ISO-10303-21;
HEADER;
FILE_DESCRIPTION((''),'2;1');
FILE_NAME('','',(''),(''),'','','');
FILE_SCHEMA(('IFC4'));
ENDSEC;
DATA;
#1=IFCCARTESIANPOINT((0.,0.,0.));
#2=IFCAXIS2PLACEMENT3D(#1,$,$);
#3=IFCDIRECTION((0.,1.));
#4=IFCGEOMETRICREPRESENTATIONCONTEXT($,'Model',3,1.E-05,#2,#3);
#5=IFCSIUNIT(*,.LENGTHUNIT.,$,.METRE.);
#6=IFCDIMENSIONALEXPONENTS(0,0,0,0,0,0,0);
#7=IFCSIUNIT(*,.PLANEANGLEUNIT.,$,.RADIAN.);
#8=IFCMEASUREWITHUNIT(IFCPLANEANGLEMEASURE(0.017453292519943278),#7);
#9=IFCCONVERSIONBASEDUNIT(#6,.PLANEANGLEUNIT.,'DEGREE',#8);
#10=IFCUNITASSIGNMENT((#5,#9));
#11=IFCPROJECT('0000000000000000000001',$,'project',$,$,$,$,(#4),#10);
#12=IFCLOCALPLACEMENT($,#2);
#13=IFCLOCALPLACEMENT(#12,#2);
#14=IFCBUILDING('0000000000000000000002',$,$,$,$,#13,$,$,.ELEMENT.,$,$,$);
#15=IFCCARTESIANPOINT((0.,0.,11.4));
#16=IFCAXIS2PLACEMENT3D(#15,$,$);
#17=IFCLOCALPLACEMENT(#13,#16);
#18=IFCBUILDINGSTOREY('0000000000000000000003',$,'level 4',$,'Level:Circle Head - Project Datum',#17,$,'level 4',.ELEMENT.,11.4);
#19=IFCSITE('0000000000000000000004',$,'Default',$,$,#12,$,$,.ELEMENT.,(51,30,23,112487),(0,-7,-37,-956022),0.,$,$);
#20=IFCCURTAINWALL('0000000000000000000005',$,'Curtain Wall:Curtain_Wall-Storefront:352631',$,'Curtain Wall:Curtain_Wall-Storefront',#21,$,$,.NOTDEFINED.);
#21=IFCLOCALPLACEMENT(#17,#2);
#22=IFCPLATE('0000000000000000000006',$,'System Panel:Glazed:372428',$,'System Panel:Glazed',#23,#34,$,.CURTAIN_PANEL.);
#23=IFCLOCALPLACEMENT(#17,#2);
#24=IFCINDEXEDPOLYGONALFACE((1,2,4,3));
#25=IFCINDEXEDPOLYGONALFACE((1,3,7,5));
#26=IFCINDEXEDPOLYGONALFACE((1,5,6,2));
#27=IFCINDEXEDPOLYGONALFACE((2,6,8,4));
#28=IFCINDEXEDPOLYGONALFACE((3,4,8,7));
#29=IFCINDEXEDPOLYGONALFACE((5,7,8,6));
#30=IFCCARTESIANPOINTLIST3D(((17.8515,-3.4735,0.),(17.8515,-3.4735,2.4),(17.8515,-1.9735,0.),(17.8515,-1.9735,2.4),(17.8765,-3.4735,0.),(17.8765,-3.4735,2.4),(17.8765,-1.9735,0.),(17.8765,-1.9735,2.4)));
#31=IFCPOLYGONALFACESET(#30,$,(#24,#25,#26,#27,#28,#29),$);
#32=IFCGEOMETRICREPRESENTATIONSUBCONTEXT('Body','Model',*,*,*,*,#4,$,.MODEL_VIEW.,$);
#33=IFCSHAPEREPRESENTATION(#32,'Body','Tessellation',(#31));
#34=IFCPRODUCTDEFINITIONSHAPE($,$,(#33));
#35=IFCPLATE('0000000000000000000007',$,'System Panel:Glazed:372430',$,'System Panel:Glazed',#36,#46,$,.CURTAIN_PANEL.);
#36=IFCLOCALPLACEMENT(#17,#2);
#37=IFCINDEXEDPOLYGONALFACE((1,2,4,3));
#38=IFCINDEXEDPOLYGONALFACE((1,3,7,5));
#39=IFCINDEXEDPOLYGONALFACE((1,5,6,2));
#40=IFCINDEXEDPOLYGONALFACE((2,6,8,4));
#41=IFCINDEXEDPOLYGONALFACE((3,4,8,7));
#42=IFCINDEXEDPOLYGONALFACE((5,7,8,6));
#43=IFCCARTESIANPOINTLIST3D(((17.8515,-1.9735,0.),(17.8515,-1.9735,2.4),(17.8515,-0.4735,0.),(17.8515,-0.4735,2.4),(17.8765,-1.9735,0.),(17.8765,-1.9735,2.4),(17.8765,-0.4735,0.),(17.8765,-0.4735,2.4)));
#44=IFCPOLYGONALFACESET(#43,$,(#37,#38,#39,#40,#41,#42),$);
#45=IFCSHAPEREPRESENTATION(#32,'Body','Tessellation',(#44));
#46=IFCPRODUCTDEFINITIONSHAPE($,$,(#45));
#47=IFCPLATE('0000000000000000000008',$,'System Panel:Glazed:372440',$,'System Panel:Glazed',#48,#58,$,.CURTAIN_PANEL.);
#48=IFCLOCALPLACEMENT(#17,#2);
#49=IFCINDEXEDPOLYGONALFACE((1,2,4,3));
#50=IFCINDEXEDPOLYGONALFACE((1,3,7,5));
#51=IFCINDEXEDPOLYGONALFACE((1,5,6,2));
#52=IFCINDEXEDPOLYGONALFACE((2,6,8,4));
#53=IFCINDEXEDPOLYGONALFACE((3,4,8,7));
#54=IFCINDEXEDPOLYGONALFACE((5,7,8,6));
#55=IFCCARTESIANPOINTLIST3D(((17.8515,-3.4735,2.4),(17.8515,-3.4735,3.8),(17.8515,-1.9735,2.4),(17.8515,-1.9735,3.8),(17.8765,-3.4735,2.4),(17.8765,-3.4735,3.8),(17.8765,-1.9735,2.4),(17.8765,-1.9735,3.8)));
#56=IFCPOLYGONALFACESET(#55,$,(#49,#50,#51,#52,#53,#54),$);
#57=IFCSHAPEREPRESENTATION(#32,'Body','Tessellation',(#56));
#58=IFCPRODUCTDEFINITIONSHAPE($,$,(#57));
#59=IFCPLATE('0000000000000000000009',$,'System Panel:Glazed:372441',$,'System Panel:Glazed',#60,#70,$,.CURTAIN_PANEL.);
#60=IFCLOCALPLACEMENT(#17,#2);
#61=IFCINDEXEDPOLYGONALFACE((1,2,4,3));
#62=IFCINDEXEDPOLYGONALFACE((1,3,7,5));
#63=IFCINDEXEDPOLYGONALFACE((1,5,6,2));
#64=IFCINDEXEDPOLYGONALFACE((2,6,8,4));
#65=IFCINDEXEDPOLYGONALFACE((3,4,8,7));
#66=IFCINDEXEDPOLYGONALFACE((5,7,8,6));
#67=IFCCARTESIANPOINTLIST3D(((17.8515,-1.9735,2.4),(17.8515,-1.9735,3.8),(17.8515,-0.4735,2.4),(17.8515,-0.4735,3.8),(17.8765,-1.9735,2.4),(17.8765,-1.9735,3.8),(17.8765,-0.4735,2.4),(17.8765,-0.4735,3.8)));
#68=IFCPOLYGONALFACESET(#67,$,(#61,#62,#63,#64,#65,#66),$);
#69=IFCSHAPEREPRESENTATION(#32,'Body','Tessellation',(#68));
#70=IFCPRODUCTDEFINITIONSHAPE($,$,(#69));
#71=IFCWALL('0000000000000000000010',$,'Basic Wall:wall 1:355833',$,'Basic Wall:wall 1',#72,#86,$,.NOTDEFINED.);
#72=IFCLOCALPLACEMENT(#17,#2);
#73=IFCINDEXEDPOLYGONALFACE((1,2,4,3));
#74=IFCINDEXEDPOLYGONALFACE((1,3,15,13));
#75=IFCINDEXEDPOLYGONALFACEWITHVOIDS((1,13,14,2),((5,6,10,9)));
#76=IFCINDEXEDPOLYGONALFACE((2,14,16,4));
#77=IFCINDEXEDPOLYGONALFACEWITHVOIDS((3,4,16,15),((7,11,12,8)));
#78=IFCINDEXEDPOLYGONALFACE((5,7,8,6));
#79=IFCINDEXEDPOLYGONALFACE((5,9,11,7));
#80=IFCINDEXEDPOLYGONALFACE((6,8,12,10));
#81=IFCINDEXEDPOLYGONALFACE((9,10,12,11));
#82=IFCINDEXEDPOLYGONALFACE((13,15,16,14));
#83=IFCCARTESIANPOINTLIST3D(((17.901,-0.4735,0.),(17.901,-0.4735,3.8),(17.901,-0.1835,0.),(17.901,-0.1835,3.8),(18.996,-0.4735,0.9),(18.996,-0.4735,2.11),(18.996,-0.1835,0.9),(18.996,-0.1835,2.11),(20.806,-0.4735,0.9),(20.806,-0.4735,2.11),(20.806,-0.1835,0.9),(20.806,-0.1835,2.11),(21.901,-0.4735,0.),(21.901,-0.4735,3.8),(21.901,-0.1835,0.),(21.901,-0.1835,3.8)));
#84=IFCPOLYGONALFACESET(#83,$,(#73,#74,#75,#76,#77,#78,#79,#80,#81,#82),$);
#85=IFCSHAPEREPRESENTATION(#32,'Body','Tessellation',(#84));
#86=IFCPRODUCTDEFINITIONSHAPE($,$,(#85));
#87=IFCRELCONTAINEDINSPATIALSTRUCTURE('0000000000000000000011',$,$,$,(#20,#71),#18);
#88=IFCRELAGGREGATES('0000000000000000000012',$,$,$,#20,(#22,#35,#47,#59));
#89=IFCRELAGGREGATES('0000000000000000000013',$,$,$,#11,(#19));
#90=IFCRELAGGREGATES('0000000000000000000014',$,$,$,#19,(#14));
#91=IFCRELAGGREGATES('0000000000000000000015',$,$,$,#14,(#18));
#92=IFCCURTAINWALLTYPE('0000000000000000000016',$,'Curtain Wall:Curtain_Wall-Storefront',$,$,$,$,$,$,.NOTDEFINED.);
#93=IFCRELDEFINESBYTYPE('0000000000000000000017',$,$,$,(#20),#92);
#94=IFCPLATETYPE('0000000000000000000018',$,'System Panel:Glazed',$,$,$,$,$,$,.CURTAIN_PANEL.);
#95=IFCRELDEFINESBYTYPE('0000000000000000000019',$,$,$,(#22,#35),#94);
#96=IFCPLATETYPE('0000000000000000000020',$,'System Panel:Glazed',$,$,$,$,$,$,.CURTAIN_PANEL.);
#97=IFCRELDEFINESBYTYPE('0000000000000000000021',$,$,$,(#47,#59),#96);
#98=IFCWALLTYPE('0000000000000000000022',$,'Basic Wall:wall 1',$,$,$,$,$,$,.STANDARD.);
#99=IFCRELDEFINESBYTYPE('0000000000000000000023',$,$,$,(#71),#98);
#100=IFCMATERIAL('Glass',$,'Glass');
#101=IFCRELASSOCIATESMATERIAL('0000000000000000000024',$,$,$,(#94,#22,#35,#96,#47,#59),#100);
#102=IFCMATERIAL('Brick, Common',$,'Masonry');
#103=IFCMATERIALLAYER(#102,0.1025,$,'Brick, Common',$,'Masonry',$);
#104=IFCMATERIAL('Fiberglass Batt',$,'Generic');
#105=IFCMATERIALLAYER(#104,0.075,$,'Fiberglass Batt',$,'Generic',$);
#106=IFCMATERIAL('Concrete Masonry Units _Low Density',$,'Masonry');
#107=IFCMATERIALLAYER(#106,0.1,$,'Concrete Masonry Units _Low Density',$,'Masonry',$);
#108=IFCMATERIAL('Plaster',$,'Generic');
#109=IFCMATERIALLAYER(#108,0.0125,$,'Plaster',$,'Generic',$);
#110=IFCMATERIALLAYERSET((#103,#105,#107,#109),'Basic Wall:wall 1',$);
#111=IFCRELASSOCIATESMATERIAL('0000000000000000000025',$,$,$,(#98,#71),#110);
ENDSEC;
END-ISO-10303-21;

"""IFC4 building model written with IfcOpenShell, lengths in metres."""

from ifc_helpers import new_model, entity, si_unit, converted_unit, direction, frame, frame_2d, origin, origin_2d_with_axis, place, context, subcontext, project, spatial, rectangle, extrude, source, transform, mapped, material, layer, layer_set, layer_usage, type_object, type_shapes, element, aggregate, save


model = new_model("IFC4")

# Units and contexts
model_context = context("Model", 3, precision=1e-05, world=origin(), true_north=direction((0.0, 1.0)))
body_context = subcontext(model_context, "Body", "Model", "MODEL_VIEW")
ifc_project = project(units=[si_unit("LENGTHUNIT", "METRE"), converted_unit("PLANEANGLEUNIT", "DEGREE", entity("IfcPlaneAngleMeasure", 0.017453292519943278), si_unit("PLANEANGLEUNIT", "RADIAN"), dimensions=[0, 0, 0, 0, 0, 0, 0])], contexts=[model_context])

# Site, building, storey
site_placement = place(None, origin())
site = spatial("IfcSite", under=ifc_project, at=site_placement, Name="Default", CompositionType="ELEMENT", RefLatitude=(51, 30, 23, 112487), RefLongitude=(0, -7, -37, -956022), RefElevation=0.0)
building_placement = place(site_placement, origin())
building = spatial("IfcBuilding", under=site, at=building_placement, CompositionType="ELEMENT")
storey_placement = place(building_placement, frame((0.0, 0.0, 11.4)))
storey = spatial("IfcBuildingStorey", under=building, at=storey_placement, Name="level 4", ObjectType="Level:Circle Head - Project Datum", LongName="level 4", CompositionType="ELEMENT", Elevation=11.4)

# Curtain wall, plates
curtain_wall_type = type_object("IfcCurtainWallType", Name="Curtain Wall:Curtain_Wall-Storefront", PredefinedType="NOTDEFINED")
curtain_wall_placement = place(storey_placement, frame((0.0, 0.0, -11.4)))
curtain_wall = element("IfcCurtainWall", 1, at=curtain_wall_placement, inside=storey, type_object=curtain_wall_type, Name="Curtain Wall:Curtain_Wall-Storefront:352631", ObjectType="Curtain Wall:Curtain_Wall-Storefront", PredefinedType="NOTDEFINED")
ifc_material_1 = material(Name="Glass", Category="Glass")
plate_type_1 = type_object("IfcPlateType", Name="System Panel:Glazed", PredefinedType="CURTAIN_PANEL", material=ifc_material_1)
shared_shape_1 = source(origin(), body_context, "Body", "SweptSolid", [
    extrude(rectangle(XDim=0.025, YDim=1.5, at=origin_2d_with_axis()), frame((0.75, 0.0125, 0.0), z_axis=(0.0, 0.0, 1.0), x_axis=(0.0, 1.0, 0.0)), (0.0, 0.0, 1.0), 2.4),
])
type_shapes(plate_type_1, [shared_shape_1])
plate_1_placement = place(curtain_wall_placement, frame((17.8765, -3.4735, 11.4), z_axis=(0.0, 0.0, 1.0), x_axis=(0.0, 1.0, 0.0)))
plate_1 = element("IfcPlate", 2, at=plate_1_placement, type_object=plate_type_1, material=ifc_material_1, Name="System Panel:Glazed:372428", ObjectType="System Panel:Glazed", PredefinedType="CURTAIN_PANEL", context=body_context, shape_type="MappedRepresentation", body=[
    mapped(shared_shape_1, transform((0.0, 0.0, 0.0), scale=1.0)),
])
plate_2_placement = place(curtain_wall_placement, frame((17.8765, -1.9735, 11.4), z_axis=(0.0, 0.0, 1.0), x_axis=(0.0, 1.0, 0.0)))
plate_2 = element("IfcPlate", 3, at=plate_2_placement, type_object=plate_type_1, material=ifc_material_1, Name="System Panel:Glazed:372430", ObjectType="System Panel:Glazed", PredefinedType="CURTAIN_PANEL", context=body_context, shape_type="MappedRepresentation", body=[
    mapped(shared_shape_1, transform((0.0, 0.0, 0.0), scale=1.0)),
])
plate_type_2 = type_object("IfcPlateType", Name="System Panel:Glazed", PredefinedType="CURTAIN_PANEL", material=ifc_material_1)
shared_shape_2 = source(origin(), body_context, "Body", "SweptSolid", [
    extrude(rectangle(XDim=0.025, YDim=1.5, at=origin_2d_with_axis()), frame((0.75, 0.0125, 0.0), z_axis=(0.0, 0.0, 1.0), x_axis=(0.0, 1.0, 0.0)), (0.0, 0.0, 1.0), 1.4),
])
type_shapes(plate_type_2, [shared_shape_2])
plate_3_placement = place(curtain_wall_placement, frame((17.8765, -3.4735, 13.8), z_axis=(0.0, 0.0, 1.0), x_axis=(0.0, 1.0, 0.0)))
plate_3 = element("IfcPlate", 4, at=plate_3_placement, type_object=plate_type_2, material=ifc_material_1, Name="System Panel:Glazed:372440", ObjectType="System Panel:Glazed", PredefinedType="CURTAIN_PANEL", context=body_context, shape_type="MappedRepresentation", body=[
    mapped(shared_shape_2, transform((0.0, 0.0, 0.0), scale=1.0)),
])
plate_4_placement = place(curtain_wall_placement, frame((17.8765, -1.9735, 13.8), z_axis=(0.0, 0.0, 1.0), x_axis=(0.0, 1.0, 0.0)))
plate_4 = element("IfcPlate", 5, at=plate_4_placement, type_object=plate_type_2, material=ifc_material_1, Name="System Panel:Glazed:372441", ObjectType="System Panel:Glazed", PredefinedType="CURTAIN_PANEL", context=body_context, shape_type="MappedRepresentation", body=[
    mapped(shared_shape_2, transform((0.0, 0.0, 0.0), scale=1.0)),
])
aggregate(curtain_wall, [plate_1, plate_2, plate_3, plate_4])

# Wall, opening
ifc_material_2 = material(Name="Brick, Common", Category="Masonry")
ifc_layer_1 = layer(ifc_material_2, 0.1025, Name="Brick, Common", Category="Masonry")
ifc_material_3 = material(Name="Fiberglass Batt", Category="Generic")
ifc_layer_2 = layer(ifc_material_3, 0.075, Name="Fiberglass Batt", Category="Generic")
ifc_material_4 = material(Name="Concrete Masonry Units _Low Density", Category="Masonry")
ifc_layer_3 = layer(ifc_material_4, 0.1, Name="Concrete Masonry Units _Low Density", Category="Masonry")
ifc_material_5 = material(Name="Plaster", Category="Generic")
ifc_layer_4 = layer(ifc_material_5, 0.0125, Name="Plaster", Category="Generic")
ifc_layer_set = layer_set([ifc_layer_1, ifc_layer_2, ifc_layer_3, ifc_layer_4], Name="Basic Wall:wall 1")
ifc_layer_usage = layer_usage(ifc_layer_set, "AXIS2", "NEGATIVE", 0.145)
wall_type = type_object("IfcWallType", Name="Basic Wall:wall 1", PredefinedType="STANDARD", material=ifc_layer_set)
wall_placement = place(storey_placement, frame((17.901, -0.3285, 0.0)))
wall = element("IfcWall", 6, at=wall_placement, inside=storey, type_object=wall_type, material=ifc_layer_usage, Name="Basic Wall:wall 1:355833", ObjectType="Basic Wall:wall 1", PredefinedType="NOTDEFINED", context=body_context, shape_type="SweptSolid", body=[
    extrude(rectangle(XDim=4.0, YDim=0.29, at=frame_2d((2.0, 0.0), x_axis=(-1.0, 0.0))), origin(), (0.0, 0.0, 1.0), 3.8),
])
opening_placement = place(wall_placement, frame((1.095, -0.145, 0.9)))
element("IfcOpeningElement", 7, at=opening_placement, cuts=wall, PredefinedType="OPENING", context=body_context, shape_type="SweptSolid", body=[
    extrude(rectangle(XDim=1.21, YDim=1.81, at=frame_2d((0.605, 0.905), x_axis=(-1.0, 0.0))), frame((0.0, 0.0, 0.0), z_axis=(0.0, 1.0, 0.0), x_axis=(0.0, 0.0, 1.0)), (0.0, 0.0, 1.0), 0.29),
])

save(model, "model.ifc")
